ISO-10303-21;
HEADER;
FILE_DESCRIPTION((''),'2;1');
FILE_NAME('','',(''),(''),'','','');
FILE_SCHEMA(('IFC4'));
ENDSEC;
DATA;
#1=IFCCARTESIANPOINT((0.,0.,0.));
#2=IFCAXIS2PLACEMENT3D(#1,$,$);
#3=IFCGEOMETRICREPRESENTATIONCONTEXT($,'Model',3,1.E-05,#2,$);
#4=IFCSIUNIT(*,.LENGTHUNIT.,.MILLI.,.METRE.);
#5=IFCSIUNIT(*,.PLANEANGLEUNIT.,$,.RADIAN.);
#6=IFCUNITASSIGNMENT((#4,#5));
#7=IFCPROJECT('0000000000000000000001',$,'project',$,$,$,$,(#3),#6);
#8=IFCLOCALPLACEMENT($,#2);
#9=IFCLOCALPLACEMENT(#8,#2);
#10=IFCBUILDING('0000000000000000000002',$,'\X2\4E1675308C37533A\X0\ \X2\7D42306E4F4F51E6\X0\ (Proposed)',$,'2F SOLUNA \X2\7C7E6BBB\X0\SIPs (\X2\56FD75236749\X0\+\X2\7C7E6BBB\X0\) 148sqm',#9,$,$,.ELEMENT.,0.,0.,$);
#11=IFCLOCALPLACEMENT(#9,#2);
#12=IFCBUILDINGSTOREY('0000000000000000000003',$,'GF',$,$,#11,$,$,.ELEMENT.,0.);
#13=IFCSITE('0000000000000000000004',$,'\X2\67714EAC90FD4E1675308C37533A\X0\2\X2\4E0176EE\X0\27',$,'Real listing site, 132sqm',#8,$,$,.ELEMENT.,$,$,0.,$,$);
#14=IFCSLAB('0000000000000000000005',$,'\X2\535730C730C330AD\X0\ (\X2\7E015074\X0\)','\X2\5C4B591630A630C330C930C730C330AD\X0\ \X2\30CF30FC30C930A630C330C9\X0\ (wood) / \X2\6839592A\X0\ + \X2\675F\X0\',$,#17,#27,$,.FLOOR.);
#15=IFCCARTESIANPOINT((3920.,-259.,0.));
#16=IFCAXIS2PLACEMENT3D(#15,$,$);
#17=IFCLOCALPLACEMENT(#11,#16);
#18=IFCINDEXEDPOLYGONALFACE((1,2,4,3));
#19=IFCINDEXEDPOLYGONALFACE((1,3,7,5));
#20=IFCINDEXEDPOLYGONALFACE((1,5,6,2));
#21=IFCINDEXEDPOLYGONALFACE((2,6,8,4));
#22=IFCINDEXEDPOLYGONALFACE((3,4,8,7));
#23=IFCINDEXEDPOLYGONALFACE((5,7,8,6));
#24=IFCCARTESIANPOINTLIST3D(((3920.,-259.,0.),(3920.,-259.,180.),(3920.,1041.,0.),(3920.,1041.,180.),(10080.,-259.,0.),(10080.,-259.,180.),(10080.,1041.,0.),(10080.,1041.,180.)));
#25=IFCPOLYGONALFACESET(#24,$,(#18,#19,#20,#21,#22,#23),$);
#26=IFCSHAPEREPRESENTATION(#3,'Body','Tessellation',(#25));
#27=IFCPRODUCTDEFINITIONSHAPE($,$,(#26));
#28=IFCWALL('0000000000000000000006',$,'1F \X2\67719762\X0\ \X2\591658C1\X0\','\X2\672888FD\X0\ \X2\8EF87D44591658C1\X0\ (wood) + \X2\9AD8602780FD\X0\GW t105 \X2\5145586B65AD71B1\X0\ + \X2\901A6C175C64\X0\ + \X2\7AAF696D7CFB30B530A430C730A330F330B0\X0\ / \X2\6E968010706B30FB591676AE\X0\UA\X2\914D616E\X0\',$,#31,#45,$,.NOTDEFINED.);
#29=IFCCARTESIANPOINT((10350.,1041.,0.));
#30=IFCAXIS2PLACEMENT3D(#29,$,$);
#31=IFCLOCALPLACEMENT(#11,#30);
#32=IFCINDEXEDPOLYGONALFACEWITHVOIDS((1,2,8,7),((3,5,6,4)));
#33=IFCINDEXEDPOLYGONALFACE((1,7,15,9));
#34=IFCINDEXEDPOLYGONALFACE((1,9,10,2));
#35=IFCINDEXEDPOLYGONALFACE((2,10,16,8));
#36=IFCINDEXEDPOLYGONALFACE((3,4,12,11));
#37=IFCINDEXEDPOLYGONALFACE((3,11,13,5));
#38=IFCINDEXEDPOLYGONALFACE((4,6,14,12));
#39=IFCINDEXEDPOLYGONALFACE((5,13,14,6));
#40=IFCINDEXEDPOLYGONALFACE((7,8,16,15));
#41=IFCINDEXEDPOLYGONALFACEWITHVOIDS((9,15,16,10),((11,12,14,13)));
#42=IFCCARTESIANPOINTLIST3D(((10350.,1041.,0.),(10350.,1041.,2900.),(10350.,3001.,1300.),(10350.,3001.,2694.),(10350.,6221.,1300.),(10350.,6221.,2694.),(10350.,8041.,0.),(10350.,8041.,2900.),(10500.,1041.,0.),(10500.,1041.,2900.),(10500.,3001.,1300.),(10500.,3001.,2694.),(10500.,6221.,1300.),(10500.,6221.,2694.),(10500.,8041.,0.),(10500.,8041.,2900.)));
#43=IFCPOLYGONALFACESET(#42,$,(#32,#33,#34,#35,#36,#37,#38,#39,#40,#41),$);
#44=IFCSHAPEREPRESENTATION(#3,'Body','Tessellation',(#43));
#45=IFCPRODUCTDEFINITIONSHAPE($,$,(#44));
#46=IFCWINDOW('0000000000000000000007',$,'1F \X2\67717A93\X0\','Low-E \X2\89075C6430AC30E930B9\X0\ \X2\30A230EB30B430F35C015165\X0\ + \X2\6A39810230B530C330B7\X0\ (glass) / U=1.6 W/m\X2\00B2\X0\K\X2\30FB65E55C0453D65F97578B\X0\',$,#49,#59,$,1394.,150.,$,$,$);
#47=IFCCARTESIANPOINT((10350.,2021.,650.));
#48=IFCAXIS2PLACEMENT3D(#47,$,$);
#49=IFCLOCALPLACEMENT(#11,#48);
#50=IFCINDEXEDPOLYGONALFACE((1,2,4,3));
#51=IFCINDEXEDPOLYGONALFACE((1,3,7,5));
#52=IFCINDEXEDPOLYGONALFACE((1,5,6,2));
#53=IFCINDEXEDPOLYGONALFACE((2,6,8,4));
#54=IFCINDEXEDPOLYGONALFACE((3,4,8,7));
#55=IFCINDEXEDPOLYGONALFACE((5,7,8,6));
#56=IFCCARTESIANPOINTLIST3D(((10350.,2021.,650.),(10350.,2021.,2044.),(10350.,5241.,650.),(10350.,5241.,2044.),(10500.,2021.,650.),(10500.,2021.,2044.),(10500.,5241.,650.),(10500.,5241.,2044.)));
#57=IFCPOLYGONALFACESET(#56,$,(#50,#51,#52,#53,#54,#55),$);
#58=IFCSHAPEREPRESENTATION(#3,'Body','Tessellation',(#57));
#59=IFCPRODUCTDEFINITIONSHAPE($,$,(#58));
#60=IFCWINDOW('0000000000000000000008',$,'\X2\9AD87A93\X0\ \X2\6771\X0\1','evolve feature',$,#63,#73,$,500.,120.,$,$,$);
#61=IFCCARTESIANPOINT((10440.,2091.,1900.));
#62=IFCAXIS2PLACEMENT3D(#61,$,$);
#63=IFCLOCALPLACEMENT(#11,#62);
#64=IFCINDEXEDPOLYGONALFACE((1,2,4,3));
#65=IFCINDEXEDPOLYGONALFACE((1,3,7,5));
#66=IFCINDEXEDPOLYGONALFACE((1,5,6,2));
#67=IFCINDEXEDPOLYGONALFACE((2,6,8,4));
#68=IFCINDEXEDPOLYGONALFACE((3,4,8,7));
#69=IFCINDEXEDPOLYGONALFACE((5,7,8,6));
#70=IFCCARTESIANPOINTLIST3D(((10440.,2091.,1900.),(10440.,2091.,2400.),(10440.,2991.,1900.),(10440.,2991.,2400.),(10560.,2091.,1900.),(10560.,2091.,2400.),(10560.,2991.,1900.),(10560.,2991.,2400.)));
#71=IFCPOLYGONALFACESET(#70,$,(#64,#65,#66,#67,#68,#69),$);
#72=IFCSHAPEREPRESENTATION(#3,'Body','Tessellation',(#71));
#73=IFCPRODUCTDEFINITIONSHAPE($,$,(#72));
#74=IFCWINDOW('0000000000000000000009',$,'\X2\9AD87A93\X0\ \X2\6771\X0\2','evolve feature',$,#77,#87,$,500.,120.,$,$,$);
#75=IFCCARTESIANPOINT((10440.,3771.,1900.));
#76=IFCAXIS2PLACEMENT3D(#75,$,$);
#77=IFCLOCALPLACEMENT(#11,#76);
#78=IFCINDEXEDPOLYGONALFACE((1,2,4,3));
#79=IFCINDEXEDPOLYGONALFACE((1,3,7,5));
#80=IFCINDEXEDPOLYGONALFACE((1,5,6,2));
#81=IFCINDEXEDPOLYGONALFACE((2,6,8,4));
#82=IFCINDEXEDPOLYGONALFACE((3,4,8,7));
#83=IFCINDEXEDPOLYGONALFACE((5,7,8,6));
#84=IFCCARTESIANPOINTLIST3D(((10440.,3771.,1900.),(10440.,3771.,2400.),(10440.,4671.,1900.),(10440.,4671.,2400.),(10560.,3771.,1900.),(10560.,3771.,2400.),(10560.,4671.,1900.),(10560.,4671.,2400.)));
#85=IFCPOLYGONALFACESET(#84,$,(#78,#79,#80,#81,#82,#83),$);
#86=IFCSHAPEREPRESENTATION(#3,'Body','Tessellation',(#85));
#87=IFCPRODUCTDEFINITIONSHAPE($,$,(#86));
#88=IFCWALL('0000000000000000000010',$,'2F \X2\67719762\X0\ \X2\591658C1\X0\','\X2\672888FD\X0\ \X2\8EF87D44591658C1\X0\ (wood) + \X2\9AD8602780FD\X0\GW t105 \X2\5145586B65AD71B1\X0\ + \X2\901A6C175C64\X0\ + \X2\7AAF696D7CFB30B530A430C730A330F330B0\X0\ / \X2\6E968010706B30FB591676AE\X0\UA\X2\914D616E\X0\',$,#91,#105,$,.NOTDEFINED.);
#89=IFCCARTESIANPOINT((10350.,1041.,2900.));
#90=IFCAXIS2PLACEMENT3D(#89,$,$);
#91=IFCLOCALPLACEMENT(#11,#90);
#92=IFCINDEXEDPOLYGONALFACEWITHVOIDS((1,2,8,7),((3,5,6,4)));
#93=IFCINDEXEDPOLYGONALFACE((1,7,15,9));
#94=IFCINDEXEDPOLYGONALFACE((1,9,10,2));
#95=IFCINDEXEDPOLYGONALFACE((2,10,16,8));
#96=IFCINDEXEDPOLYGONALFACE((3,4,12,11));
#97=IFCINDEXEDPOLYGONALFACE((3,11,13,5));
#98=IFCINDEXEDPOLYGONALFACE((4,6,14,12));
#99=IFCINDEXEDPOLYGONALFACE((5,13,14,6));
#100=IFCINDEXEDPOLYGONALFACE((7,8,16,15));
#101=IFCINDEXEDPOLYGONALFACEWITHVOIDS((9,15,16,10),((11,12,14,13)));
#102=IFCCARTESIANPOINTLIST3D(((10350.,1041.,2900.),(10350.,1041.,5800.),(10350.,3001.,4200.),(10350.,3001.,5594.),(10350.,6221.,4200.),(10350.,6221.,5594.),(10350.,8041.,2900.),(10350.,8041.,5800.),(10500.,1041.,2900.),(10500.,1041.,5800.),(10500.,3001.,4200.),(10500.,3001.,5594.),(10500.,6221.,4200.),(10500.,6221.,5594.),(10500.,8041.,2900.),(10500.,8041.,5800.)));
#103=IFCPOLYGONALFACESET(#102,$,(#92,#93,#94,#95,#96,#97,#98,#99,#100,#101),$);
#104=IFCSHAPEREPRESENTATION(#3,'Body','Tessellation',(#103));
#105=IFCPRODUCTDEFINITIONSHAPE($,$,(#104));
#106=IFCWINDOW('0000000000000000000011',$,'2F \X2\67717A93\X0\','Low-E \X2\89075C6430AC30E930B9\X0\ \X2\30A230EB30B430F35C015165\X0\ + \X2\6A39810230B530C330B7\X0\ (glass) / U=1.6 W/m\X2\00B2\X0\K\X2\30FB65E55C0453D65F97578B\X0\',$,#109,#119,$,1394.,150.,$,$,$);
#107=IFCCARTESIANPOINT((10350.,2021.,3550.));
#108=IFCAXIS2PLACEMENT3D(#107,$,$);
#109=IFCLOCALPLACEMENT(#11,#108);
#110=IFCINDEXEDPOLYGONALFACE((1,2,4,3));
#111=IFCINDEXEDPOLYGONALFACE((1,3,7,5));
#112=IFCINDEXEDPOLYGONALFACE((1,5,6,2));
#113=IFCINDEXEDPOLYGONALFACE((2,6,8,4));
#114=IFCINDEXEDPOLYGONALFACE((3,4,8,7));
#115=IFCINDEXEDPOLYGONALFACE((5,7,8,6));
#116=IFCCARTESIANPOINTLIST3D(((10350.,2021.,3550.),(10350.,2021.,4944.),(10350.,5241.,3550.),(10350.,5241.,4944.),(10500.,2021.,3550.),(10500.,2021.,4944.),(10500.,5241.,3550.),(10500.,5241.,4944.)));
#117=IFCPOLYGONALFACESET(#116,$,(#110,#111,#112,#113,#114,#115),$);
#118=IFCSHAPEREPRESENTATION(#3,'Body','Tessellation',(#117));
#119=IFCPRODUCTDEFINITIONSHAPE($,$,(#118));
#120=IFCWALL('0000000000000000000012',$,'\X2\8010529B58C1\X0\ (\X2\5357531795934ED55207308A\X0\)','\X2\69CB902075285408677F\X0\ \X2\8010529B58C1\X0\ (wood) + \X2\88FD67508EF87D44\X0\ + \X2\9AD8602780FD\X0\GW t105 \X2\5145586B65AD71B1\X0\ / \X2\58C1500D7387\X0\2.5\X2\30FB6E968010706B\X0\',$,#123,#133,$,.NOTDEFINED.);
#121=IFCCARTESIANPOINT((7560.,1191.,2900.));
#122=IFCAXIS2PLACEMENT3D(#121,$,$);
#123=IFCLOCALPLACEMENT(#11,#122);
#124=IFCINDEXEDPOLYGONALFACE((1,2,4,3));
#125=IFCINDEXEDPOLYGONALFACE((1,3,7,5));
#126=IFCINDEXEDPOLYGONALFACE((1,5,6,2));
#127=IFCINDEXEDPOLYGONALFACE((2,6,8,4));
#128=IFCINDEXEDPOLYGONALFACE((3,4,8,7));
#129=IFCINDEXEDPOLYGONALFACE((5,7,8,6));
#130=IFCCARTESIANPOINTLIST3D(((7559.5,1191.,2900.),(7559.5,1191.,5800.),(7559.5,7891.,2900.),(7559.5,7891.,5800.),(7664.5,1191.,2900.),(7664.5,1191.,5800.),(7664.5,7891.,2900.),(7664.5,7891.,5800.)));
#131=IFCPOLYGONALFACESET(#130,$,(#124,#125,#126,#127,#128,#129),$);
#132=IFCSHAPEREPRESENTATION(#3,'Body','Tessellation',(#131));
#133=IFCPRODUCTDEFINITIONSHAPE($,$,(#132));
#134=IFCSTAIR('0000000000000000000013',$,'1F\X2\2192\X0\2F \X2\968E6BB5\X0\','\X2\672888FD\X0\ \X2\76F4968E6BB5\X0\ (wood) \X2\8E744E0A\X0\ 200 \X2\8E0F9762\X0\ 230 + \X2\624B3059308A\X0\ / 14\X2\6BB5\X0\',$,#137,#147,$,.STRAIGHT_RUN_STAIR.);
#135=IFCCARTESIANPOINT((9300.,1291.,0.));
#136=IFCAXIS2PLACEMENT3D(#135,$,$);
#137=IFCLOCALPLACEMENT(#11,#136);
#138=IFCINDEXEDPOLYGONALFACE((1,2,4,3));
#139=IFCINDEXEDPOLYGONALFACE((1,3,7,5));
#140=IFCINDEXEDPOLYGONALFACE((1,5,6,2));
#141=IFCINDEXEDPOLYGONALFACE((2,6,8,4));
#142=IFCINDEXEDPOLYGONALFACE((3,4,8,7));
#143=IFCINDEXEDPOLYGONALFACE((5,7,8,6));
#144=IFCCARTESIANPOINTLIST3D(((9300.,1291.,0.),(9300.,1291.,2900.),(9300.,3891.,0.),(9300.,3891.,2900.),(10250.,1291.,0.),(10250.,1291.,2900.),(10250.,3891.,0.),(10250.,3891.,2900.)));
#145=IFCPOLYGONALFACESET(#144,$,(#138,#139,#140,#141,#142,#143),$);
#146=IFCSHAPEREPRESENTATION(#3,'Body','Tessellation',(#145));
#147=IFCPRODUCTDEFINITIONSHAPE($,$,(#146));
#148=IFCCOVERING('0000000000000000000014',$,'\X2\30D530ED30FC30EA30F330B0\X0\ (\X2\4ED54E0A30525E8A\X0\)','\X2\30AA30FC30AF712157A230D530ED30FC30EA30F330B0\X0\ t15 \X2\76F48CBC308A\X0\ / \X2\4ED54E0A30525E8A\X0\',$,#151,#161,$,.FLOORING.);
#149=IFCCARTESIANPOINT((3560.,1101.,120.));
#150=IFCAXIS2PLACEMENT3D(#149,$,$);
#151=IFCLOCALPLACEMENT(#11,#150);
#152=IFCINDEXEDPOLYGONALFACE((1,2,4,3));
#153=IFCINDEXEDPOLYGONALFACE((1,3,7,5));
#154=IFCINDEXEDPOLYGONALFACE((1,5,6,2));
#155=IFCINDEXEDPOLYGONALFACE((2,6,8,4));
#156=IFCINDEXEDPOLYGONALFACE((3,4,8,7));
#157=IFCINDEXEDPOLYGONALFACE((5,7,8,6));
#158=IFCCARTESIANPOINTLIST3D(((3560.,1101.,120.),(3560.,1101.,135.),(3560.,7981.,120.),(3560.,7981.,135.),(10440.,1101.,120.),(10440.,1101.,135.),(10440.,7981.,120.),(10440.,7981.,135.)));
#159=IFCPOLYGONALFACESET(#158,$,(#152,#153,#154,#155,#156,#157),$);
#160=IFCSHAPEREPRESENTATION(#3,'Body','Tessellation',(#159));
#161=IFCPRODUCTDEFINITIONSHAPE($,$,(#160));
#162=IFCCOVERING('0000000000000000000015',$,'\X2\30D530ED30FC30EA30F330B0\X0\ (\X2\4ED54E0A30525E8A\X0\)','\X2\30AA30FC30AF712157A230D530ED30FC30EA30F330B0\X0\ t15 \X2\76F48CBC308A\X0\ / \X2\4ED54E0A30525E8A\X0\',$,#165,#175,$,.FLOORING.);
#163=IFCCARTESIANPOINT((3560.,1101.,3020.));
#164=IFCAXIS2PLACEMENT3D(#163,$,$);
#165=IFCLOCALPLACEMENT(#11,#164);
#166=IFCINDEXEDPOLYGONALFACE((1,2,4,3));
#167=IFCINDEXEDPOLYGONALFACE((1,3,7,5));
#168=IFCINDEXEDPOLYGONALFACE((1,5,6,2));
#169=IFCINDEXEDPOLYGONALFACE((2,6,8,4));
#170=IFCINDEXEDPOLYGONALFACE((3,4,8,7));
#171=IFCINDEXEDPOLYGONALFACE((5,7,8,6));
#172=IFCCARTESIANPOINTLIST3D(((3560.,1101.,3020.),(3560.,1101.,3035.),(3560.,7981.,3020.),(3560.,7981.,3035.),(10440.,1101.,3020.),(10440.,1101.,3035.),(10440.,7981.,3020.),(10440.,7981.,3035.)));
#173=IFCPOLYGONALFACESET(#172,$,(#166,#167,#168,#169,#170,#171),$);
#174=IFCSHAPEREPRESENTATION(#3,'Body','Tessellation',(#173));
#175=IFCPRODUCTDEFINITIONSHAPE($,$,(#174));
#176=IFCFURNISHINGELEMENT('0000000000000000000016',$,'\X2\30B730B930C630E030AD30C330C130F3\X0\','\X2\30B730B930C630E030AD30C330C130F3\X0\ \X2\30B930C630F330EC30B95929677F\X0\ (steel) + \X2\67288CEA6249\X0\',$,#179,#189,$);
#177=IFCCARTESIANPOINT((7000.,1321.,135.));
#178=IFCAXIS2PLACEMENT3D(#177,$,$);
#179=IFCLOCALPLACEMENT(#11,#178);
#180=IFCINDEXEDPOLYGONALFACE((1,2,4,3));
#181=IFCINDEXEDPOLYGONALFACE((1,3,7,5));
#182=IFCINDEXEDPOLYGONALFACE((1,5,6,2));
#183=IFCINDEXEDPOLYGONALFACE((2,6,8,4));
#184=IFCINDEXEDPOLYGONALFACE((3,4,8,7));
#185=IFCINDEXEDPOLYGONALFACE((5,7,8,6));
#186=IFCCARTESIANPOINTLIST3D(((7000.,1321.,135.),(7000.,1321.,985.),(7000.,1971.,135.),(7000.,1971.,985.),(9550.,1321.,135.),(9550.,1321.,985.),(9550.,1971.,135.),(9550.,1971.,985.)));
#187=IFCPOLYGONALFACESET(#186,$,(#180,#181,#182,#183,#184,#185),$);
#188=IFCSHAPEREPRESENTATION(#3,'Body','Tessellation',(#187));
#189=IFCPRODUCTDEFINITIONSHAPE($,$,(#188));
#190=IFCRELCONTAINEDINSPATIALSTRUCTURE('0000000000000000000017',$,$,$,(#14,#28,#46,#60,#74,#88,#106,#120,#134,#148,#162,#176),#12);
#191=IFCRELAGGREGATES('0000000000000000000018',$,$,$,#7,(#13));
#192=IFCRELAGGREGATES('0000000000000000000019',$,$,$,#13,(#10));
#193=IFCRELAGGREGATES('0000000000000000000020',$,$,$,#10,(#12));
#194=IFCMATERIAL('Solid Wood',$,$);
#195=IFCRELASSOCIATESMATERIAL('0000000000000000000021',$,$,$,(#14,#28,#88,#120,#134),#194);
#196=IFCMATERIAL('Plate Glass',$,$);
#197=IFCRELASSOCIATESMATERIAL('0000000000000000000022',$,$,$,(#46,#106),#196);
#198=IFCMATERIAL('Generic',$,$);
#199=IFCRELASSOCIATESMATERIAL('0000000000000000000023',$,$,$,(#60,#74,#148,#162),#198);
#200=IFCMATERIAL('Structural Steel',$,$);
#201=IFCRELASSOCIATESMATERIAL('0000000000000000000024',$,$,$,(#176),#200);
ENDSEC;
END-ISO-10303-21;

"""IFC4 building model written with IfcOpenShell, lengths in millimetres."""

from ifc_helpers import new_model, si_unit, frame, frame_2d, origin, place, context, project, spatial, rectangle, extrude, material, element, fill, save


model = new_model("IFC4")

# Units and contexts
model_context = context("Model", 3, precision=1e-05, world=origin())
ifc_project = project(units=[si_unit("LENGTHUNIT", "METRE", prefix="MILLI"), si_unit("PLANEANGLEUNIT", "RADIAN")], contexts=[model_context])

# Site, building, storey
site_placement = place(None, origin())
site = spatial("IfcSite", under=ifc_project, at=site_placement, Name="東京都世田谷区2丁目27", ObjectType="Real listing site, 132sqm", CompositionType="ELEMENT", RefElevation=0.0)
building_placement = place(site_placement, origin())
building = spatial("IfcBuilding", under=site, at=building_placement, Name="世田谷区 終の住処 (Proposed)", ObjectType="2F SOLUNA 籾殻SIPs (国産杉+籾殻) 148sqm", CompositionType="ELEMENT", ElevationOfRefHeight=0.0, ElevationOfTerrain=0.0)
storey_placement = place(building_placement, origin())
storey = spatial("IfcBuildingStorey", under=building, at=storey_placement, Name="GF", CompositionType="ELEMENT", Elevation=0.0)

# Slab
ifc_material_1 = material(Name="Solid Wood")
slab_placement = place(storey_placement, frame((3920.0, -259.0, 0.0)))
element("IfcSlab", 1, at=slab_placement, inside=storey, material=ifc_material_1, Name="南デッキ (縁側)", Description="屋外ウッドデッキ ハードウッド (wood) / 根太 + 束", PredefinedType="FLOOR", context=model_context, shape_type="SweptSolid", body=[
    extrude(rectangle(XDim=6160.0, YDim=1300.0, at=frame_2d((3080.0, 650.0))), frame((3920.0, -259.0, 0.0)), (0.0, 0.0, 1.0), 180.0),
])

# Wall, openings, windows
wall_1_placement = place(storey_placement, frame((10350.0, 1041.0, 0.0)))
wall_1 = element("IfcWall", 2, at=wall_1_placement, inside=storey, material=ifc_material_1, Name="1F 東面 外壁", Description="木製 軸組外壁 (wood) + 高性能GW t105 充填断熱 + 通気層 + 窯業系サイディング / 準耐火・外皮UA配慮", PredefinedType="NOTDEFINED", context=model_context, shape_type="SweptSolid", body=[
    extrude(rectangle(XDim=150.0, YDim=7000.0, at=frame_2d((75.0, 3500.0))), frame((10350.0, 1041.0, 0.0)), (0.0, 0.0, 1.0), 2900.0),
])
opening_1_placement = place(storey_placement, frame((10350.0, 2021.0, 650.0)))
opening_1 = element("IfcOpeningElement", 3, at=opening_1_placement, cuts=wall_1, PredefinedType="NOTDEFINED", context=model_context, shape_type="SweptSolid", body=[
    extrude(rectangle(XDim=150.0, YDim=3220.0, at=frame_2d((75.0, 1610.0))), frame((10350.0, 2021.0, 650.0)), (0.0, 0.0, 1.0), 1394.0),
])
opening_2_placement = place(storey_placement, frame((10440.0, 2091.0, 1900.0)))
opening_2 = element("IfcOpeningElement", 4, at=opening_2_placement, cuts=wall_1, PredefinedType="NOTDEFINED", context=model_context, shape_type="SweptSolid", body=[
    extrude(rectangle(XDim=120.0, YDim=900.0, at=frame_2d((60.0, 450.0))), frame((10440.0, 2091.0, 1900.0)), (0.0, 0.0, 1.0), 500.0),
])
opening_3_placement = place(storey_placement, frame((10440.0, 3771.0, 1900.0)))
opening_3 = element("IfcOpeningElement", 5, at=opening_3_placement, cuts=wall_1, PredefinedType="NOTDEFINED", context=model_context, shape_type="SweptSolid", body=[
    extrude(rectangle(XDim=120.0, YDim=900.0, at=frame_2d((60.0, 450.0))), frame((10440.0, 3771.0, 1900.0)), (0.0, 0.0, 1.0), 500.0),
])
ifc_material_2 = material(Name="Plate Glass")
window_1_placement = place(storey_placement, frame((10350.0, 2021.0, 650.0)))
window_1 = element("IfcWindow", 6, at=window_1_placement, inside=storey, material=ifc_material_2, Name="1F 東窓", Description="Low-E 複層ガラス アルゴン封入 + 樹脂サッシ (glass) / U=1.6 W/m²K・日射取得型", OverallHeight=1394.0, OverallWidth=150.0, context=model_context, shape_type="SweptSolid", body=[
    extrude(rectangle(XDim=150.0, YDim=3220.0, at=frame_2d((75.0, 1610.0))), frame((10350.0, 2021.0, 650.0)), (0.0, 0.0, 1.0), 1394.0),
])
fill(opening_1, window_1)
ifc_material_3 = material(Name="Generic")
window_2_placement = place(storey_placement, frame((10440.0, 2091.0, 1900.0)))
window_2 = element("IfcWindow", 7, at=window_2_placement, inside=storey, material=ifc_material_3, Name="高窓 東1", Description="evolve feature", OverallHeight=500.0, OverallWidth=120.0, context=model_context, shape_type="SweptSolid", body=[
    extrude(rectangle(XDim=120.0, YDim=900.0, at=frame_2d((60.0, 450.0))), frame((10440.0, 2091.0, 1900.0)), (0.0, 0.0, 1.0), 500.0),
])
fill(opening_2, window_2)
window_3_placement = place(storey_placement, frame((10440.0, 3771.0, 1900.0)))
window_3 = element("IfcWindow", 8, at=window_3_placement, inside=storey, material=ifc_material_3, Name="高窓 東2", Description="evolve feature", OverallHeight=500.0, OverallWidth=120.0, context=model_context, shape_type="SweptSolid", body=[
    extrude(rectangle(XDim=120.0, YDim=900.0, at=frame_2d((60.0, 450.0))), frame((10440.0, 3771.0, 1900.0)), (0.0, 0.0, 1.0), 500.0),
])
fill(opening_3, window_3)

# Wall, opening, window
wall_2_placement = place(storey_placement, frame((10350.0, 1041.0, 2900.0)))
wall_2 = element("IfcWall", 9, at=wall_2_placement, inside=storey, material=ifc_material_1, Name="2F 東面 外壁", Description="木製 軸組外壁 (wood) + 高性能GW t105 充填断熱 + 通気層 + 窯業系サイディング / 準耐火・外皮UA配慮", PredefinedType="NOTDEFINED", context=model_context, shape_type="SweptSolid", body=[
    extrude(rectangle(XDim=150.0, YDim=7000.0, at=frame_2d((75.0, 3500.0))), frame((10350.0, 1041.0, 2900.0)), (0.0, 0.0, 1.0), 2900.0),
])
opening_4_placement = place(storey_placement, frame((10350.0, 2021.0, 3550.0)))
opening_4 = element("IfcOpeningElement", 10, at=opening_4_placement, cuts=wall_2, PredefinedType="NOTDEFINED", context=model_context, shape_type="SweptSolid", body=[
    extrude(rectangle(XDim=150.0, YDim=3220.0, at=frame_2d((75.0, 1610.0))), frame((10350.0, 2021.0, 3550.0)), (0.0, 0.0, 1.0), 1394.0),
])
window_4_placement = place(storey_placement, frame((10350.0, 2021.0, 3550.0)))
window_4 = element("IfcWindow", 11, at=window_4_placement, inside=storey, material=ifc_material_2, Name="2F 東窓", Description="Low-E 複層ガラス アルゴン封入 + 樹脂サッシ (glass) / U=1.6 W/m²K・日射取得型", OverallHeight=1394.0, OverallWidth=150.0, context=model_context, shape_type="SweptSolid", body=[
    extrude(rectangle(XDim=150.0, YDim=3220.0, at=frame_2d((75.0, 1610.0))), frame((10350.0, 2021.0, 3550.0)), (0.0, 0.0, 1.0), 1394.0),
])
fill(opening_4, window_4)

# Wall
wall_3_placement = place(storey_placement, frame((7560.0, 1191.0, 2900.0)))
element("IfcWall", 12, at=wall_3_placement, inside=storey, material=ifc_material_1, Name="耐力壁 (南北間仕切り)", Description="構造用合板 耐力壁 (wood) + 製材軸組 + 高性能GW t105 充填断熱 / 壁倍率2.5・準耐火", PredefinedType="NOTDEFINED", context=model_context, shape_type="SweptSolid", body=[
    extrude(rectangle(XDim=105.0, YDim=6700.0, at=frame_2d((52.0, 3350.0))), frame((7560.0, 1191.0, 2900.0)), (0.0, 0.0, 1.0), 2900.0),
])

# Stair
stair_placement = place(storey_placement, frame((9300.0, 1291.0, 0.0)))
element("IfcStair", 13, at=stair_placement, inside=storey, material=ifc_material_1, Name="1F→2F 階段", Description="木製 直階段 (wood) 蹴上 200 踏面 230 + 手すり / 14段", PredefinedType="STRAIGHT_RUN_STAIR", context=model_context, shape_type="SweptSolid", body=[
    extrude(rectangle(XDim=950.0, YDim=2600.0, at=frame_2d((475.0, 1300.0))), frame((9300.0, 1291.0, 0.0)), (0.0, 0.0, 1.0), 2900.0),
])

# Coverings
covering_1_placement = place(storey_placement, frame((3560.0, 1101.0, 120.0)))
element("IfcCovering", 14, at=covering_1_placement, inside=storey, material=ifc_material_3, Name="フローリング (仕上げ床)", Description="オーク無垢フローリング t15 直貼り / 仕上げ床", PredefinedType="FLOORING", context=model_context, shape_type="SweptSolid", body=[
    extrude(rectangle(XDim=6880.0, YDim=6880.0, at=frame_2d((3440.0, 3440.0))), frame((3560.0, 1101.0, 120.0)), (0.0, 0.0, 1.0), 15.0),
])
covering_2_placement = place(storey_placement, frame((3560.0, 1101.0, 3020.0)))
element("IfcCovering", 15, at=covering_2_placement, inside=storey, material=ifc_material_3, Name="フローリング (仕上げ床)", Description="オーク無垢フローリング t15 直貼り / 仕上げ床", PredefinedType="FLOORING", context=model_context, shape_type="SweptSolid", body=[
    extrude(rectangle(XDim=6880.0, YDim=6880.0, at=frame_2d((3440.0, 3440.0))), frame((3560.0, 1101.0, 3020.0)), (0.0, 0.0, 1.0), 15.0),
])

# Furnishing element
ifc_material_4 = material(Name="Structural Steel")
furnishing_1_placement = place(storey_placement, frame((7000.0, 1321.0, 135.0)))
element("IfcFurnishingElement", 16, at=furnishing_1_placement, inside=storey, material=ifc_material_4, Name="システムキッチン", Description="システムキッチン ステンレス天板 (steel) + 木質扉", context=model_context, shape_type="SweptSolid", body=[
    extrude(rectangle(XDim=2550.0, YDim=650.0, at=frame_2d((1275.0, 325.0))), frame((7000.0, 1321.0, 135.0)), (0.0, 0.0, 1.0), 850.0),
])

save(model, "model.ifc")
